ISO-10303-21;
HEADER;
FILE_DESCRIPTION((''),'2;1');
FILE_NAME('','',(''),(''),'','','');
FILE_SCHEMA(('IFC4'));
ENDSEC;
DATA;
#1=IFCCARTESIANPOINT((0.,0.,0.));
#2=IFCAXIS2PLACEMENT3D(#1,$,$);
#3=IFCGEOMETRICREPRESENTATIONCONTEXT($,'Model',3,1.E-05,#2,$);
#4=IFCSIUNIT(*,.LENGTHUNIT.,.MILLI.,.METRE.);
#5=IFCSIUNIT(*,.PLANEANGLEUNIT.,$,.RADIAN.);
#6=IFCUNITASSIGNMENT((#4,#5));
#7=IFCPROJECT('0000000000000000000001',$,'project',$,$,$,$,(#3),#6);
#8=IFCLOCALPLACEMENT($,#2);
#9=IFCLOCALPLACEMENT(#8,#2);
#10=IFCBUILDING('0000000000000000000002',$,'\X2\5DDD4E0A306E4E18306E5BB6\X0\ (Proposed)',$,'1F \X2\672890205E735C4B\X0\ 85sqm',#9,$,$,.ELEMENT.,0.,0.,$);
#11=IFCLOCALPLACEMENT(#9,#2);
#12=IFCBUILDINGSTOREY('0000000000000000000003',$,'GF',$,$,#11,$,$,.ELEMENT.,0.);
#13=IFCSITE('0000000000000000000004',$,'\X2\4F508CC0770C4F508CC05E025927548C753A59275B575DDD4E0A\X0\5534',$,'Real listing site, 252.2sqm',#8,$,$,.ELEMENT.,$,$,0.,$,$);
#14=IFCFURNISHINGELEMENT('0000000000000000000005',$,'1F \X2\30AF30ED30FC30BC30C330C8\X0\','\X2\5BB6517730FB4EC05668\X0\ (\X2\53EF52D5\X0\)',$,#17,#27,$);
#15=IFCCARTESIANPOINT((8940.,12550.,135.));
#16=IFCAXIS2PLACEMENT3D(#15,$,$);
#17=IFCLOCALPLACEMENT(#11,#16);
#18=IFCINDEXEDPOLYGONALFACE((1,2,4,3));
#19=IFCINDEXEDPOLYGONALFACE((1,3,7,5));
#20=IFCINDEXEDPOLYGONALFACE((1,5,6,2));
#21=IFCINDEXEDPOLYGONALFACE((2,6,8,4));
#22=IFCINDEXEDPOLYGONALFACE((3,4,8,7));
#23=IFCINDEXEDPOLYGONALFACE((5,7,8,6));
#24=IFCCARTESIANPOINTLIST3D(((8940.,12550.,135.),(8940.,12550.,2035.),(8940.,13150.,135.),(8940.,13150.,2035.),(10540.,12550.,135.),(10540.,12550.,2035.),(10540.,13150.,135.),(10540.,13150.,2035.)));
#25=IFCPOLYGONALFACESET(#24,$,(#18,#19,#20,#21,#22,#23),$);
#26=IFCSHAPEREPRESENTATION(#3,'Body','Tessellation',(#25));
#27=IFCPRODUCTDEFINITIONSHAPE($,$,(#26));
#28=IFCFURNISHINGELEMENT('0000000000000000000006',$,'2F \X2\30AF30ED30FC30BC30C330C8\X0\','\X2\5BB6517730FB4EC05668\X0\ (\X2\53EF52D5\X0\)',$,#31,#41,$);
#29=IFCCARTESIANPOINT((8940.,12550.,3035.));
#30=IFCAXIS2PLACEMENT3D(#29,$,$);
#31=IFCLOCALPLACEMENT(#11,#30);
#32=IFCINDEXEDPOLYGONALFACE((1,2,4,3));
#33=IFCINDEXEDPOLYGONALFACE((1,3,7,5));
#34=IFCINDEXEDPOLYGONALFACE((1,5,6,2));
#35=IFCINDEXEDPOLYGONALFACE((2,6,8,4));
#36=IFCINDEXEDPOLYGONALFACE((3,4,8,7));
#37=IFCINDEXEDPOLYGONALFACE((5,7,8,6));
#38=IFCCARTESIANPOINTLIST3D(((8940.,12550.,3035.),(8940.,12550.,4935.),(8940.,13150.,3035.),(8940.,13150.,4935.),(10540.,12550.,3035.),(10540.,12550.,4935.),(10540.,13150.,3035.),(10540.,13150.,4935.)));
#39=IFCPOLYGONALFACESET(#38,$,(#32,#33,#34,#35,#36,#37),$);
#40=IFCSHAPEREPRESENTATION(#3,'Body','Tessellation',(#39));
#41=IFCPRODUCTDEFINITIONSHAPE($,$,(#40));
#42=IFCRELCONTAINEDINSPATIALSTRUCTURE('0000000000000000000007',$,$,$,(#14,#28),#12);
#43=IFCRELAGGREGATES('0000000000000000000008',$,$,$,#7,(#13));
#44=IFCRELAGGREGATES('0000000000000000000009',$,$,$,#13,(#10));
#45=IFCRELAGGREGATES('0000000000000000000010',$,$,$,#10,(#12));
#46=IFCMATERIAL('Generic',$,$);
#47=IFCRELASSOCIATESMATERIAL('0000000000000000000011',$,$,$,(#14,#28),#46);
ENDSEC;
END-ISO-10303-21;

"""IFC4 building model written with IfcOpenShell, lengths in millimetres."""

from ifc_helpers import new_model, si_unit, frame, frame_2d, origin, place, context, project, spatial, rectangle, extrude, material, element, save


model = new_model("IFC4")

# Units and contexts
model_context = context("Model", 3, precision=1e-05, world=origin())
ifc_project = project(units=[si_unit("LENGTHUNIT", "METRE", prefix="MILLI"), si_unit("PLANEANGLEUNIT", "RADIAN")], contexts=[model_context])

# Site, building, storey
site_placement = place(None, origin())
site = spatial("IfcSite", under=ifc_project, at=site_placement, Name="佐賀県佐賀市大和町大字川上5534", ObjectType="Real listing site, 252.2sqm", CompositionType="ELEMENT", RefElevation=0.0)
building_placement = place(site_placement, origin())
building = spatial("IfcBuilding", under=site, at=building_placement, Name="川上の丘の家 (Proposed)", ObjectType="1F 木造平屋 85sqm", CompositionType="ELEMENT", ElevationOfRefHeight=0.0, ElevationOfTerrain=0.0)
storey_placement = place(building_placement, origin())
storey = spatial("IfcBuildingStorey", under=building, at=storey_placement, Name="GF", CompositionType="ELEMENT", Elevation=0.0)

# Shared definitions
ifc_material_1 = material(Name="Generic")

# Furnishing elements
furnishing_1_placement = place(storey_placement, frame((8940.0, 12550.0, 135.0)))
element("IfcFurnishingElement", 1, at=furnishing_1_placement, inside=storey, material=ifc_material_1, Name="1F クローゼット", Description="家具・什器 (可動)", context=model_context, shape_type="SweptSolid", body=[
    extrude(rectangle(XDim=1600.0, YDim=600.0, at=frame_2d((800.0, 300.0))), frame((8940.0, 12550.0, 135.0)), (0.0, 0.0, 1.0), 1900.0),
])
furnishing_2_placement = place(storey_placement, frame((8940.0, 12550.0, 3035.0)))
element("IfcFurnishingElement", 2, at=furnishing_2_placement, inside=storey, material=ifc_material_1, Name="2F クローゼット", Description="家具・什器 (可動)", context=model_context, shape_type="SweptSolid", body=[
    extrude(rectangle(XDim=1600.0, YDim=600.0, at=frame_2d((800.0, 300.0))), frame((8940.0, 12550.0, 3035.0)), (0.0, 0.0, 1.0), 1900.0),
])

save(model, "model.ifc")
